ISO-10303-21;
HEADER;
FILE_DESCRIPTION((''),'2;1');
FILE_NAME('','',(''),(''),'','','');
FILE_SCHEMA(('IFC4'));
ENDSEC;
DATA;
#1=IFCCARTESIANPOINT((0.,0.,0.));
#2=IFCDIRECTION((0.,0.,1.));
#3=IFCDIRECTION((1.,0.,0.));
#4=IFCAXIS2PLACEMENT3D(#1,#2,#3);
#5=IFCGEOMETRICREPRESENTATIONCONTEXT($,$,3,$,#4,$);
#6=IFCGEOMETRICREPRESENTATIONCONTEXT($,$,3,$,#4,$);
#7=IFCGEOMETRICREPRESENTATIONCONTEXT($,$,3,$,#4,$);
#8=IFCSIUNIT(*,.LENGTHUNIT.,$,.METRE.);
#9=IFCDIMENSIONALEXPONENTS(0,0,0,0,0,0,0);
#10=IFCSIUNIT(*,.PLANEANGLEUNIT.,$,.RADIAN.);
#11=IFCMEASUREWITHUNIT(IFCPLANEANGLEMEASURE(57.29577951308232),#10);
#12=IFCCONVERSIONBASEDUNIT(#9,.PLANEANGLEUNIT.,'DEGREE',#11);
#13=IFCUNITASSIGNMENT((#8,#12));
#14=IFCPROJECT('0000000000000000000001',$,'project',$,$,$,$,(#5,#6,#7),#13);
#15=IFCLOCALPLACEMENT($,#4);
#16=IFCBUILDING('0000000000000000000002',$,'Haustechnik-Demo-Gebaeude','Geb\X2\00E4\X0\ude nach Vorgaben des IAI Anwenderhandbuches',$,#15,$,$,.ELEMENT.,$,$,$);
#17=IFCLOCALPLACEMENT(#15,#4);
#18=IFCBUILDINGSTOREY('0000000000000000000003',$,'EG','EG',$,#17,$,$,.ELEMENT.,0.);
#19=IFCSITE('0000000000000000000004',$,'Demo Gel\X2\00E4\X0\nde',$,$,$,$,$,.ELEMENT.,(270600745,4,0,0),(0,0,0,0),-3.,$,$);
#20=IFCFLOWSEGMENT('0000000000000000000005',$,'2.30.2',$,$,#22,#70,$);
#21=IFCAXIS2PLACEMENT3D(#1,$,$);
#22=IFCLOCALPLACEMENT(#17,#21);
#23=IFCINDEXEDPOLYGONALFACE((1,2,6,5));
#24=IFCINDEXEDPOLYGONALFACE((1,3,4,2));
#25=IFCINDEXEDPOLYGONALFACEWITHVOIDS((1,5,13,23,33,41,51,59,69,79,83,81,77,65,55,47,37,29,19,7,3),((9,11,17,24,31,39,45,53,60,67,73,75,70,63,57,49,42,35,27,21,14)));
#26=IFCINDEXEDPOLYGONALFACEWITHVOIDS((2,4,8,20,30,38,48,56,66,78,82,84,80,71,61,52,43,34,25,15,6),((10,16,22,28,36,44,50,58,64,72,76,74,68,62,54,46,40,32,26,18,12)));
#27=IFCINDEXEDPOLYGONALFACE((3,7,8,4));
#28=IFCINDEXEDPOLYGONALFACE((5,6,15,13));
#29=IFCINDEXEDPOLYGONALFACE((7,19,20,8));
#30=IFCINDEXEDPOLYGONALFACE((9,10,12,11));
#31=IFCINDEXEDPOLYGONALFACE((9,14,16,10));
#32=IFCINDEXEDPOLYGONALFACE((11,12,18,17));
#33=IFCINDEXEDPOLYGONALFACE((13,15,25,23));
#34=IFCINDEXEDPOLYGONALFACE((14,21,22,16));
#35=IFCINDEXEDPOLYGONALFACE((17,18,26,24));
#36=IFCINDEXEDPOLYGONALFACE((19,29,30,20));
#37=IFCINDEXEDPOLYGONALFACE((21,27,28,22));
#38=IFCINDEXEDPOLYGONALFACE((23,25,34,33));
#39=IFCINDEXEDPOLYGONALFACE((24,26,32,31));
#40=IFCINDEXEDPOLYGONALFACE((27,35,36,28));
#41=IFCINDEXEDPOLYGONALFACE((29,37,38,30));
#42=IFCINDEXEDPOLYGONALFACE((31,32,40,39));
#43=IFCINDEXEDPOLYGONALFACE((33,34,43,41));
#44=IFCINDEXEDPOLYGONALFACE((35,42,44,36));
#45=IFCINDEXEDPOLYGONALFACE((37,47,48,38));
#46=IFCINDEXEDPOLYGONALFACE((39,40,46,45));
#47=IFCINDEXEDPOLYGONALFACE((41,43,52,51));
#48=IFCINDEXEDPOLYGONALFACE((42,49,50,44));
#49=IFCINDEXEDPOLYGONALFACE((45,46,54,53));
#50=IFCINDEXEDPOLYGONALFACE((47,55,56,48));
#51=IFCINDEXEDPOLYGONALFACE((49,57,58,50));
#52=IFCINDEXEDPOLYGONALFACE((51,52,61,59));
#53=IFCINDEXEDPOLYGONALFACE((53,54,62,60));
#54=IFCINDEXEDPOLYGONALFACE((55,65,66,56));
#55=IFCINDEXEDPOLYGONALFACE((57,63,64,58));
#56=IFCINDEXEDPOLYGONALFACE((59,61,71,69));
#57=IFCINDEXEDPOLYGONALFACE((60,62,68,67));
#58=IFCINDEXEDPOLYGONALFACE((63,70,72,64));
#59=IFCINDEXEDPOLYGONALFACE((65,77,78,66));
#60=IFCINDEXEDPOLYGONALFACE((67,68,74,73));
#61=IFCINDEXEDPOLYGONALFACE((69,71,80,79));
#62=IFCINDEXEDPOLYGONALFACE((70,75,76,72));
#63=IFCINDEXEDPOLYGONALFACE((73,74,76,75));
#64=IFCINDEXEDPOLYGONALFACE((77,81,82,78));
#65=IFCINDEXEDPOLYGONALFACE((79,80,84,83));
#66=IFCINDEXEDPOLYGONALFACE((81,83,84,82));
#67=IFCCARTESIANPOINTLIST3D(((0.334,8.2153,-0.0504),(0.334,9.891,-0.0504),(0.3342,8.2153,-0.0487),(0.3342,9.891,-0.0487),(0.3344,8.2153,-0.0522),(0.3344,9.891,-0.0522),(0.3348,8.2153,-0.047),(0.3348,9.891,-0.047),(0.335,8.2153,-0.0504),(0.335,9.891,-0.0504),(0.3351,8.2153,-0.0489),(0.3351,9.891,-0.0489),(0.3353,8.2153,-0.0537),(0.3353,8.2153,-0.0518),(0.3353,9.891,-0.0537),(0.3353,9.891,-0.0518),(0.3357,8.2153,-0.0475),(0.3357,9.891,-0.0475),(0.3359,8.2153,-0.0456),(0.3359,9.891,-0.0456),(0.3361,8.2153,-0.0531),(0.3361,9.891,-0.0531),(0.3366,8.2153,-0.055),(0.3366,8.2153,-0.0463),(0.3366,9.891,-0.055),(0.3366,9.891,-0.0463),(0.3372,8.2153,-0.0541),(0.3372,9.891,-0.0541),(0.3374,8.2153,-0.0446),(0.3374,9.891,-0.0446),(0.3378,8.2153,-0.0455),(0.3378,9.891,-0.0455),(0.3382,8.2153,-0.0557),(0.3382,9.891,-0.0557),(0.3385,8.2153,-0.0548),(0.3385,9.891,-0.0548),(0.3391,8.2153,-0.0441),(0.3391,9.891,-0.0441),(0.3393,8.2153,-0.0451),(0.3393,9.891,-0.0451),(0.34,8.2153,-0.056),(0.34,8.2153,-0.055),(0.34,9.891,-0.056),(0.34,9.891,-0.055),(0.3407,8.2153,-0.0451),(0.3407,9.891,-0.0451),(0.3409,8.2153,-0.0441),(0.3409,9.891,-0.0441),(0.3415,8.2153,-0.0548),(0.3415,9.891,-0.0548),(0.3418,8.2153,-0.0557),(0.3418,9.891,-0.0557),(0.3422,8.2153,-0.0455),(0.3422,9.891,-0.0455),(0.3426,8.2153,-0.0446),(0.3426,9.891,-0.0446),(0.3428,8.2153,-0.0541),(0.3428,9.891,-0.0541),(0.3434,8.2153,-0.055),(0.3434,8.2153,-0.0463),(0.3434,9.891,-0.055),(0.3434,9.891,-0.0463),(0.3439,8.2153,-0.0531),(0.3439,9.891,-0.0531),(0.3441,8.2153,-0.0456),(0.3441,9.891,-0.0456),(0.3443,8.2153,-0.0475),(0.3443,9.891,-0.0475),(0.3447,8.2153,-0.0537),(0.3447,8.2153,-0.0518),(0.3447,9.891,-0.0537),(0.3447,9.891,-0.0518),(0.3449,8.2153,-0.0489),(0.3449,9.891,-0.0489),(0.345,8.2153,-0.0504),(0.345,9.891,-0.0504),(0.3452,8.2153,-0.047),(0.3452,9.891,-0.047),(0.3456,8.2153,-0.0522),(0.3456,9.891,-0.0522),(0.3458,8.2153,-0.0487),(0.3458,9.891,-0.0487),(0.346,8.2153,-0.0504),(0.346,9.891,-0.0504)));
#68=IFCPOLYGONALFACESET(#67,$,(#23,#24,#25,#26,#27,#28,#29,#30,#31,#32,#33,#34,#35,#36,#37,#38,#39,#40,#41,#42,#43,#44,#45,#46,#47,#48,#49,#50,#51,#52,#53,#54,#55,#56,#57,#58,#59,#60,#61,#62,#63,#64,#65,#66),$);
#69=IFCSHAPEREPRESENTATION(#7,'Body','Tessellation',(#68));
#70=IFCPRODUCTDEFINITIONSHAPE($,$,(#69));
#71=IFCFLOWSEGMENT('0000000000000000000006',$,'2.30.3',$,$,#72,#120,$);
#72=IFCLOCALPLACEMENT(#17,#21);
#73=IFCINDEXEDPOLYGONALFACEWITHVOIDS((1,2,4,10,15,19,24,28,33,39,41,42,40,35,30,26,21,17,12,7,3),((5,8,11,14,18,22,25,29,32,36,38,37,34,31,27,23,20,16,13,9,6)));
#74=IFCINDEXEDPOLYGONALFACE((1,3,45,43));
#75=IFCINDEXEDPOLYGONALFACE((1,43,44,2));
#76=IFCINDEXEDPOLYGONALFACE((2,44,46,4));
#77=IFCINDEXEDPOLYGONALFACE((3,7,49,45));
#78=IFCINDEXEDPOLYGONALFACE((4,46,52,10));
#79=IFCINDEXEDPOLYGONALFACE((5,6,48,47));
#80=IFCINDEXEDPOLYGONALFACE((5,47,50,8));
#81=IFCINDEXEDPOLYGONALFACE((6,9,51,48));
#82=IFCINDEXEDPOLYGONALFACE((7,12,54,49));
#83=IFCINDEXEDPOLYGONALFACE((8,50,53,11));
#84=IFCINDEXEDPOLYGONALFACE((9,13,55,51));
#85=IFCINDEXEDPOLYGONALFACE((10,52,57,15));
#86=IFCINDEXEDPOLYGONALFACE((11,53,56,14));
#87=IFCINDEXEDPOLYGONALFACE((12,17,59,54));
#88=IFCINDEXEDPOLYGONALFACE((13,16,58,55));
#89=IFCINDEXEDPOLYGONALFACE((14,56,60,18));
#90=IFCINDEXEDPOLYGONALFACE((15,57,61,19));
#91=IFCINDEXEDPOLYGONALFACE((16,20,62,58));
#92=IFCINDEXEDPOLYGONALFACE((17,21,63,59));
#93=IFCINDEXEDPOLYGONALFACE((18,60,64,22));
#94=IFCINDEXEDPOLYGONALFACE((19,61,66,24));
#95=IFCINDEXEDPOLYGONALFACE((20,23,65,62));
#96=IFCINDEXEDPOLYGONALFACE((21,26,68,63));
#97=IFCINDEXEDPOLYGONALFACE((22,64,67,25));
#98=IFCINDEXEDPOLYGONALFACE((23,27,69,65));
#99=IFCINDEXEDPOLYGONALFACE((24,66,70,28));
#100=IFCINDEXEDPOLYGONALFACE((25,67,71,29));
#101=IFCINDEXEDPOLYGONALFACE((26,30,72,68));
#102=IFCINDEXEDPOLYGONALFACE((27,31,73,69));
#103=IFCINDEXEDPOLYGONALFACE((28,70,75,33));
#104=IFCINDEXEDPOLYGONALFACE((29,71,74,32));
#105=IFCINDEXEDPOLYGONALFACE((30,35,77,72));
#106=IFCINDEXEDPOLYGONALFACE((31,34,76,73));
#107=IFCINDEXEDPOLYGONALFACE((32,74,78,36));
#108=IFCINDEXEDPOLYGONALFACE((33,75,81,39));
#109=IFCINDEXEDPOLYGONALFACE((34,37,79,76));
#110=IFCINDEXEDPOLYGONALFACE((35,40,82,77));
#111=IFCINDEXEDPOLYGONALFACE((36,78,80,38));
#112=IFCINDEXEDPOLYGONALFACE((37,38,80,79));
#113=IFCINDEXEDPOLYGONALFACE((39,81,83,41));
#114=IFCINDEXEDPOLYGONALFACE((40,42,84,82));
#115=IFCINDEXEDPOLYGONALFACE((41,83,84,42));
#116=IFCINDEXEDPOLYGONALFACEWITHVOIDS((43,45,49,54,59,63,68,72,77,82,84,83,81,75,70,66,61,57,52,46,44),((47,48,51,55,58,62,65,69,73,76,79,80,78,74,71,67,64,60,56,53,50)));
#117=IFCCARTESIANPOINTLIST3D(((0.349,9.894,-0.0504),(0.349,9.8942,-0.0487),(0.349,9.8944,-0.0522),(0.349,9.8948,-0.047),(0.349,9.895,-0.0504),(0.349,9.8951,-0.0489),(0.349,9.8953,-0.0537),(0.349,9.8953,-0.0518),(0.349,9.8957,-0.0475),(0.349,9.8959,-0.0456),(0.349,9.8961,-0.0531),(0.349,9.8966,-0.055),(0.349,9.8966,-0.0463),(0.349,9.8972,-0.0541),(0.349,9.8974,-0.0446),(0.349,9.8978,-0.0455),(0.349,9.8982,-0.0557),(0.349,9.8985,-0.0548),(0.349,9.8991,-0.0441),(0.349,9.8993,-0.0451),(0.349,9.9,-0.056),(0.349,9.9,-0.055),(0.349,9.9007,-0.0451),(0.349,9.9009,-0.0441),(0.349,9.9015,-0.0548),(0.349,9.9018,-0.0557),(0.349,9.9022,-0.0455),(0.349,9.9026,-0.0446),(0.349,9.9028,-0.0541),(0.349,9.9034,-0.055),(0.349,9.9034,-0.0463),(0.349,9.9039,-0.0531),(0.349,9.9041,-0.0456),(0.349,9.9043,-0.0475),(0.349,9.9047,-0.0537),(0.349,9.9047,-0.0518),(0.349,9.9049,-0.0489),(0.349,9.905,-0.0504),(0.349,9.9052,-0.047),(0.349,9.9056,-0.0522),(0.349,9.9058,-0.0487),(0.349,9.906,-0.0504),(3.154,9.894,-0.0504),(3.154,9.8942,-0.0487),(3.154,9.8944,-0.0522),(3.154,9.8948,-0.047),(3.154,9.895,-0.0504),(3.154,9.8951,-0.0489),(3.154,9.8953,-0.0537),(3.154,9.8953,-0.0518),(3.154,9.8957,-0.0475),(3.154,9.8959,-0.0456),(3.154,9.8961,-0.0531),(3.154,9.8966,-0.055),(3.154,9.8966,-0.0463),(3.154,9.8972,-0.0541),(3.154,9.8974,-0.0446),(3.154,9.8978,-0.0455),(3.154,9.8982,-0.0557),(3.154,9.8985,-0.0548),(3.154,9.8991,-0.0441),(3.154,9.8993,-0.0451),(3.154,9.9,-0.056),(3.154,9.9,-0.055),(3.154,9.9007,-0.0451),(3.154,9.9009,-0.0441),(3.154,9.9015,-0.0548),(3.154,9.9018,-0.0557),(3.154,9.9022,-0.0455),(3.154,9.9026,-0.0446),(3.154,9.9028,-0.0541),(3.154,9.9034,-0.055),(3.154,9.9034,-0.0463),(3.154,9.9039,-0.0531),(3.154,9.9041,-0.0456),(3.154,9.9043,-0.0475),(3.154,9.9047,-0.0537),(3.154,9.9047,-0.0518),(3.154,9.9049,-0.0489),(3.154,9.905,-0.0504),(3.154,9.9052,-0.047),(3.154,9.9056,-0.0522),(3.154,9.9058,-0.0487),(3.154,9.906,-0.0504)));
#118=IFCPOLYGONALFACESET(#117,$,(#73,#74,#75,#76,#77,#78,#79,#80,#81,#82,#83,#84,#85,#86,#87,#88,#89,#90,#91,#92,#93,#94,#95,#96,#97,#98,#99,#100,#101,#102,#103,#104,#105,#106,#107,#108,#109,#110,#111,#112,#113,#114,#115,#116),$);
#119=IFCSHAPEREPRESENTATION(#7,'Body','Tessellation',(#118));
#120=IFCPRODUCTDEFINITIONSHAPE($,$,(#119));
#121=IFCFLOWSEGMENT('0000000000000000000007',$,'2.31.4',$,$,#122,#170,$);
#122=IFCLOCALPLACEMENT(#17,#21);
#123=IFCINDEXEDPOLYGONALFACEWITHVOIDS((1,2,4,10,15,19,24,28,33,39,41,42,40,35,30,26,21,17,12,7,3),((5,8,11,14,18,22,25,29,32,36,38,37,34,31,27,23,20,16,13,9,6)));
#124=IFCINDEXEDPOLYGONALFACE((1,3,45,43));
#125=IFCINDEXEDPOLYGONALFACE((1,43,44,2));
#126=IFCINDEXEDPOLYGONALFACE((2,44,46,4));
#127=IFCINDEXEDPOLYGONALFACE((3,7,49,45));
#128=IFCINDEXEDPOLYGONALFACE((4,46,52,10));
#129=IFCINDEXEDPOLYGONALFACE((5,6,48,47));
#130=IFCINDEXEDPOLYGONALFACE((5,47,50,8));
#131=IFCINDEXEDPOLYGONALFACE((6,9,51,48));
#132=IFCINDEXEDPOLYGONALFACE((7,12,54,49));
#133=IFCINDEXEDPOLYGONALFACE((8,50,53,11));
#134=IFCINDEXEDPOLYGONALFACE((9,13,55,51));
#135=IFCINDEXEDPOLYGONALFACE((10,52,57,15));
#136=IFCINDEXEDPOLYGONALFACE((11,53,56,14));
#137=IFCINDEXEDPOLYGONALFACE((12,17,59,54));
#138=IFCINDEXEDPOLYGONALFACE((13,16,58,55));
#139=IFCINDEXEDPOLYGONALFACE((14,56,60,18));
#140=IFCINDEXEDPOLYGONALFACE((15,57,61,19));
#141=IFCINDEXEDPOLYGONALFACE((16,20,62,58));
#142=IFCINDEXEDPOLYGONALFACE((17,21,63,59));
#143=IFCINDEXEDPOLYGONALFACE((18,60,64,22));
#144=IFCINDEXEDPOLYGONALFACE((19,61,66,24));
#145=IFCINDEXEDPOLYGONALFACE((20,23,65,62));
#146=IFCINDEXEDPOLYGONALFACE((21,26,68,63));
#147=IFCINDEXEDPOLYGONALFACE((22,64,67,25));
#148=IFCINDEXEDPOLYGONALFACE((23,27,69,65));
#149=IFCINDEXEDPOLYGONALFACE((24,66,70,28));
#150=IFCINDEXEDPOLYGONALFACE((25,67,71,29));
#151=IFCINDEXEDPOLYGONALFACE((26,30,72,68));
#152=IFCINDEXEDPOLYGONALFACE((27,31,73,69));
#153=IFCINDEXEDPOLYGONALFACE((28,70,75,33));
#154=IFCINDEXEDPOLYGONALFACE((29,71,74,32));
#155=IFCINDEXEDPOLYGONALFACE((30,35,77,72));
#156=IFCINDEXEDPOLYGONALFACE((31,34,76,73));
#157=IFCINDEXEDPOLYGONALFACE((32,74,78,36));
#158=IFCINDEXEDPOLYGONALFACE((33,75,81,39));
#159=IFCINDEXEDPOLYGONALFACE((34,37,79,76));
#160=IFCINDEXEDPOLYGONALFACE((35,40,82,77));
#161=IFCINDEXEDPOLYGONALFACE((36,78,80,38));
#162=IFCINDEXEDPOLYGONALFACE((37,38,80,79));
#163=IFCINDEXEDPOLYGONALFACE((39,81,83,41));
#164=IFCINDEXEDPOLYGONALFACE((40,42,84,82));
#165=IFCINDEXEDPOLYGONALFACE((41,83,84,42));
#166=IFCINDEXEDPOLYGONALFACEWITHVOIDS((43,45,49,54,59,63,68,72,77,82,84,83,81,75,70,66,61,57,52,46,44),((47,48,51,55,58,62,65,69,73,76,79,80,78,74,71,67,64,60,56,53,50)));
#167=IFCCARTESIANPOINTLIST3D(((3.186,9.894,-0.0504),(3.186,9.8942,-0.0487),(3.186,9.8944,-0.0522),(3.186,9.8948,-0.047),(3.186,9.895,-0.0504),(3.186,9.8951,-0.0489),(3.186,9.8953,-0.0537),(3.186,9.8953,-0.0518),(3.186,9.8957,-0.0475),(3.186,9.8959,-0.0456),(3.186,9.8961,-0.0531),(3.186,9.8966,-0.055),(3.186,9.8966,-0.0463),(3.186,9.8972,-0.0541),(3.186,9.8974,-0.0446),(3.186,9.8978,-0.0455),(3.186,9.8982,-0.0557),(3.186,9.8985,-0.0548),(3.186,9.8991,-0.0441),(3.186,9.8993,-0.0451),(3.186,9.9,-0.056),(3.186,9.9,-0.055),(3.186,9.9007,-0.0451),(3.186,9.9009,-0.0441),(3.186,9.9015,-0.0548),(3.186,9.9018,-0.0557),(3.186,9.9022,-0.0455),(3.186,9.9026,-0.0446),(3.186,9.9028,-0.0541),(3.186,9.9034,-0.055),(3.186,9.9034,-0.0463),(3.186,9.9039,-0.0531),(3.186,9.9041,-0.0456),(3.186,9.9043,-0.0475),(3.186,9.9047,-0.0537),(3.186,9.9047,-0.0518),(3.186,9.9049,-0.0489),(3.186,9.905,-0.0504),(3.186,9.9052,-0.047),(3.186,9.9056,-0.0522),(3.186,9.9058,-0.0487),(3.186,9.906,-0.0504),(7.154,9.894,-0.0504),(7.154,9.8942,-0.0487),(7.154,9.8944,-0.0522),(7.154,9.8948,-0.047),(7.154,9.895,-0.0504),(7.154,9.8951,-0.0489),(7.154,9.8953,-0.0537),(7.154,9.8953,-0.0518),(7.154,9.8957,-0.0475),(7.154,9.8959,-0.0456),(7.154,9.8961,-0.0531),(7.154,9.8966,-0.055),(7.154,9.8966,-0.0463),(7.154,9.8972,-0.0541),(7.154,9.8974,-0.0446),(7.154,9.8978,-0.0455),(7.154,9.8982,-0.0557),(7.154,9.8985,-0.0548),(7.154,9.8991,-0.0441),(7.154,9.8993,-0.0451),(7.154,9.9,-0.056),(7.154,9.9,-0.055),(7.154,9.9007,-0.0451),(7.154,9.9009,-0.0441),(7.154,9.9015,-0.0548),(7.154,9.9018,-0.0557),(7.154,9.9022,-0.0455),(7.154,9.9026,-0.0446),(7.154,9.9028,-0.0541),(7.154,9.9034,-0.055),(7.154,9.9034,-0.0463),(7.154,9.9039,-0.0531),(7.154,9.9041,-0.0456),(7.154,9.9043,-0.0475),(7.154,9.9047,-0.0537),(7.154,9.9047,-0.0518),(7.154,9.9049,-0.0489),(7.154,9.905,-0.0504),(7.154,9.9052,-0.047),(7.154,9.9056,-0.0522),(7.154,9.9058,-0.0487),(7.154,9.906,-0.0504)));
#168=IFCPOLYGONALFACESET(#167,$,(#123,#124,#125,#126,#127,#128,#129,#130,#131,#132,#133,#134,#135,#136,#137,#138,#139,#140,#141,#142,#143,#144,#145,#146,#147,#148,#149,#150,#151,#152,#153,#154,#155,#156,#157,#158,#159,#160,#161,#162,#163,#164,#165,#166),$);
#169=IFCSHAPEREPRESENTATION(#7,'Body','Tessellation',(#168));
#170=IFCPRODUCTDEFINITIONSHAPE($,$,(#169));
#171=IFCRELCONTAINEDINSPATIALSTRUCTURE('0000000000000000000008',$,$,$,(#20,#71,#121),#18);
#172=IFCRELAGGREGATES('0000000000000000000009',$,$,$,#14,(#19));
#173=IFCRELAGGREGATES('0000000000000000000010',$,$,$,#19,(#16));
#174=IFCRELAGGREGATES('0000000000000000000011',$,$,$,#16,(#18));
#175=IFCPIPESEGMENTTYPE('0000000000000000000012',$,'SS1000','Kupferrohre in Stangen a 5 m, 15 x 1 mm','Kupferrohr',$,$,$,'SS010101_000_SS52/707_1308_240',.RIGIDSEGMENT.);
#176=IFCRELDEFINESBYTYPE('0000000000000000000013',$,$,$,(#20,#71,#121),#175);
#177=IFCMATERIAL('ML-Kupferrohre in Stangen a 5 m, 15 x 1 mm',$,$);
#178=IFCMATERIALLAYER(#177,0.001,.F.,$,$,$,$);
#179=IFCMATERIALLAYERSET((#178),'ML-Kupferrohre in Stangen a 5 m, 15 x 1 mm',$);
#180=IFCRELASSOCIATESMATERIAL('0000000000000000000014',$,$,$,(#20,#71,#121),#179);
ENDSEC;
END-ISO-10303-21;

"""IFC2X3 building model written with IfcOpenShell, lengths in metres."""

from ifc_helpers import new_model, entity, si_unit, converted_unit, frame, origin_with_axes, origin_2d_with_axis, place, context, project, spatial, hollow_circle, extrude, material, layer, layer_set, layer_usage, type_object, element, save


model = new_model("IFC2X3")

# Units and contexts
context_of_model_1 = context(None, 3, world=origin_with_axes())
context_of_model_2 = context(None, 3, world=origin_with_axes())
context_of_model_3 = context(None, 3, world=origin_with_axes())
ifc_project = project(units=[si_unit("LENGTHUNIT", "METRE"), converted_unit("PLANEANGLEUNIT", "DEGREE", entity("IfcPlaneAngleMeasure", 57.29577951308232), si_unit("PLANEANGLEUNIT", "RADIAN"), dimensions=[0, 0, 0, 0, 0, 0, 0])], contexts=[context_of_model_1, context_of_model_2, context_of_model_3])

# Site, building, storey
site = spatial("IfcSite", under=ifc_project, Name="Demo Gelände", CompositionType="ELEMENT", RefLatitude=(270600745, 4, 0, 0), RefLongitude=(0, 0, 0, 0), RefElevation=-3.0)
building_placement = place(None, origin_with_axes())
building = spatial("IfcBuilding", under=site, at=building_placement, Name="Haustechnik-Demo-Gebaeude", Description="Gebäude nach Vorgaben des IAI Anwenderhandbuches", CompositionType="ELEMENT")
storey_placement = place(building_placement, origin_with_axes())
storey = spatial("IfcBuildingStorey", under=building, at=storey_placement, Name="EG", Description="EG", CompositionType="ELEMENT", Elevation=0.0)

# Flow segments
ifc_material_1 = material(Name="ML-Kupferrohre in Stangen a 5 m, 15 x 1 mm")
ifc_layer_1 = layer(ifc_material_1, 0.001, ventilated=False)
ifc_layer_set_1 = layer_set([ifc_layer_1], Name="ML-Kupferrohre in Stangen a 5 m, 15 x 1 mm")
ifc_layer_usage_1 = layer_usage(ifc_layer_set_1, "AXIS2", "POSITIVE", 0.0)
pipe_segment_type_1 = type_object("IfcPipeSegmentType", Name="SS1000", Description="Kupferrohre in Stangen a 5 m, 15 x 1 mm", ApplicableOccurrence="Kupferrohr", ElementType="SS010101_000_SS52/707_1308_240", PredefinedType="RIGIDSEGMENT")
flow_segment_1_placement = place(storey_placement, frame((0.34, 8.2153, -0.05), z_axis=(0.0, 1.0, 0.0), x_axis=(0.0, 0.0, -1.0)))
element("IfcFlowSegment", 1, at=flow_segment_1_placement, inside=storey, type_object=pipe_segment_type_1, material=ifc_layer_usage_1, Name="2.30.2", context=context_of_model_3, shape_type="SweptSolid", body=[
    extrude(hollow_circle(Radius=0.006, WallThickness=0.001, at=origin_2d_with_axis()), origin_with_axes(), (0.0, 0.0, 1.0), 1.6757),
])
flow_segment_2_placement = place(storey_placement, frame((0.349, 9.9, -0.05), z_axis=(1.0, 0.0, 0.0), x_axis=(0.0, 0.0, -1.0)))
element("IfcFlowSegment", 2, at=flow_segment_2_placement, inside=storey, type_object=pipe_segment_type_1, material=ifc_layer_usage_1, Name="2.30.3", context=context_of_model_3, shape_type="SweptSolid", body=[
    extrude(hollow_circle(Radius=0.006, WallThickness=0.001, at=origin_2d_with_axis()), origin_with_axes(), (0.0, 0.0, 1.0), 2.805),
])
flow_segment_3_placement = place(storey_placement, frame((3.186, 9.9, -0.05), z_axis=(1.0, 0.0, 0.0), x_axis=(0.0, 0.0, -1.0)))
element("IfcFlowSegment", 3, at=flow_segment_3_placement, inside=storey, type_object=pipe_segment_type_1, material=ifc_layer_usage_1, Name="2.31.4", context=context_of_model_3, shape_type="SweptSolid", body=[
    extrude(hollow_circle(Radius=0.006, WallThickness=0.001, at=origin_2d_with_axis()), origin_with_axes(), (0.0, 0.0, 1.0), 3.968),
])

save(model, "model.ifc")
